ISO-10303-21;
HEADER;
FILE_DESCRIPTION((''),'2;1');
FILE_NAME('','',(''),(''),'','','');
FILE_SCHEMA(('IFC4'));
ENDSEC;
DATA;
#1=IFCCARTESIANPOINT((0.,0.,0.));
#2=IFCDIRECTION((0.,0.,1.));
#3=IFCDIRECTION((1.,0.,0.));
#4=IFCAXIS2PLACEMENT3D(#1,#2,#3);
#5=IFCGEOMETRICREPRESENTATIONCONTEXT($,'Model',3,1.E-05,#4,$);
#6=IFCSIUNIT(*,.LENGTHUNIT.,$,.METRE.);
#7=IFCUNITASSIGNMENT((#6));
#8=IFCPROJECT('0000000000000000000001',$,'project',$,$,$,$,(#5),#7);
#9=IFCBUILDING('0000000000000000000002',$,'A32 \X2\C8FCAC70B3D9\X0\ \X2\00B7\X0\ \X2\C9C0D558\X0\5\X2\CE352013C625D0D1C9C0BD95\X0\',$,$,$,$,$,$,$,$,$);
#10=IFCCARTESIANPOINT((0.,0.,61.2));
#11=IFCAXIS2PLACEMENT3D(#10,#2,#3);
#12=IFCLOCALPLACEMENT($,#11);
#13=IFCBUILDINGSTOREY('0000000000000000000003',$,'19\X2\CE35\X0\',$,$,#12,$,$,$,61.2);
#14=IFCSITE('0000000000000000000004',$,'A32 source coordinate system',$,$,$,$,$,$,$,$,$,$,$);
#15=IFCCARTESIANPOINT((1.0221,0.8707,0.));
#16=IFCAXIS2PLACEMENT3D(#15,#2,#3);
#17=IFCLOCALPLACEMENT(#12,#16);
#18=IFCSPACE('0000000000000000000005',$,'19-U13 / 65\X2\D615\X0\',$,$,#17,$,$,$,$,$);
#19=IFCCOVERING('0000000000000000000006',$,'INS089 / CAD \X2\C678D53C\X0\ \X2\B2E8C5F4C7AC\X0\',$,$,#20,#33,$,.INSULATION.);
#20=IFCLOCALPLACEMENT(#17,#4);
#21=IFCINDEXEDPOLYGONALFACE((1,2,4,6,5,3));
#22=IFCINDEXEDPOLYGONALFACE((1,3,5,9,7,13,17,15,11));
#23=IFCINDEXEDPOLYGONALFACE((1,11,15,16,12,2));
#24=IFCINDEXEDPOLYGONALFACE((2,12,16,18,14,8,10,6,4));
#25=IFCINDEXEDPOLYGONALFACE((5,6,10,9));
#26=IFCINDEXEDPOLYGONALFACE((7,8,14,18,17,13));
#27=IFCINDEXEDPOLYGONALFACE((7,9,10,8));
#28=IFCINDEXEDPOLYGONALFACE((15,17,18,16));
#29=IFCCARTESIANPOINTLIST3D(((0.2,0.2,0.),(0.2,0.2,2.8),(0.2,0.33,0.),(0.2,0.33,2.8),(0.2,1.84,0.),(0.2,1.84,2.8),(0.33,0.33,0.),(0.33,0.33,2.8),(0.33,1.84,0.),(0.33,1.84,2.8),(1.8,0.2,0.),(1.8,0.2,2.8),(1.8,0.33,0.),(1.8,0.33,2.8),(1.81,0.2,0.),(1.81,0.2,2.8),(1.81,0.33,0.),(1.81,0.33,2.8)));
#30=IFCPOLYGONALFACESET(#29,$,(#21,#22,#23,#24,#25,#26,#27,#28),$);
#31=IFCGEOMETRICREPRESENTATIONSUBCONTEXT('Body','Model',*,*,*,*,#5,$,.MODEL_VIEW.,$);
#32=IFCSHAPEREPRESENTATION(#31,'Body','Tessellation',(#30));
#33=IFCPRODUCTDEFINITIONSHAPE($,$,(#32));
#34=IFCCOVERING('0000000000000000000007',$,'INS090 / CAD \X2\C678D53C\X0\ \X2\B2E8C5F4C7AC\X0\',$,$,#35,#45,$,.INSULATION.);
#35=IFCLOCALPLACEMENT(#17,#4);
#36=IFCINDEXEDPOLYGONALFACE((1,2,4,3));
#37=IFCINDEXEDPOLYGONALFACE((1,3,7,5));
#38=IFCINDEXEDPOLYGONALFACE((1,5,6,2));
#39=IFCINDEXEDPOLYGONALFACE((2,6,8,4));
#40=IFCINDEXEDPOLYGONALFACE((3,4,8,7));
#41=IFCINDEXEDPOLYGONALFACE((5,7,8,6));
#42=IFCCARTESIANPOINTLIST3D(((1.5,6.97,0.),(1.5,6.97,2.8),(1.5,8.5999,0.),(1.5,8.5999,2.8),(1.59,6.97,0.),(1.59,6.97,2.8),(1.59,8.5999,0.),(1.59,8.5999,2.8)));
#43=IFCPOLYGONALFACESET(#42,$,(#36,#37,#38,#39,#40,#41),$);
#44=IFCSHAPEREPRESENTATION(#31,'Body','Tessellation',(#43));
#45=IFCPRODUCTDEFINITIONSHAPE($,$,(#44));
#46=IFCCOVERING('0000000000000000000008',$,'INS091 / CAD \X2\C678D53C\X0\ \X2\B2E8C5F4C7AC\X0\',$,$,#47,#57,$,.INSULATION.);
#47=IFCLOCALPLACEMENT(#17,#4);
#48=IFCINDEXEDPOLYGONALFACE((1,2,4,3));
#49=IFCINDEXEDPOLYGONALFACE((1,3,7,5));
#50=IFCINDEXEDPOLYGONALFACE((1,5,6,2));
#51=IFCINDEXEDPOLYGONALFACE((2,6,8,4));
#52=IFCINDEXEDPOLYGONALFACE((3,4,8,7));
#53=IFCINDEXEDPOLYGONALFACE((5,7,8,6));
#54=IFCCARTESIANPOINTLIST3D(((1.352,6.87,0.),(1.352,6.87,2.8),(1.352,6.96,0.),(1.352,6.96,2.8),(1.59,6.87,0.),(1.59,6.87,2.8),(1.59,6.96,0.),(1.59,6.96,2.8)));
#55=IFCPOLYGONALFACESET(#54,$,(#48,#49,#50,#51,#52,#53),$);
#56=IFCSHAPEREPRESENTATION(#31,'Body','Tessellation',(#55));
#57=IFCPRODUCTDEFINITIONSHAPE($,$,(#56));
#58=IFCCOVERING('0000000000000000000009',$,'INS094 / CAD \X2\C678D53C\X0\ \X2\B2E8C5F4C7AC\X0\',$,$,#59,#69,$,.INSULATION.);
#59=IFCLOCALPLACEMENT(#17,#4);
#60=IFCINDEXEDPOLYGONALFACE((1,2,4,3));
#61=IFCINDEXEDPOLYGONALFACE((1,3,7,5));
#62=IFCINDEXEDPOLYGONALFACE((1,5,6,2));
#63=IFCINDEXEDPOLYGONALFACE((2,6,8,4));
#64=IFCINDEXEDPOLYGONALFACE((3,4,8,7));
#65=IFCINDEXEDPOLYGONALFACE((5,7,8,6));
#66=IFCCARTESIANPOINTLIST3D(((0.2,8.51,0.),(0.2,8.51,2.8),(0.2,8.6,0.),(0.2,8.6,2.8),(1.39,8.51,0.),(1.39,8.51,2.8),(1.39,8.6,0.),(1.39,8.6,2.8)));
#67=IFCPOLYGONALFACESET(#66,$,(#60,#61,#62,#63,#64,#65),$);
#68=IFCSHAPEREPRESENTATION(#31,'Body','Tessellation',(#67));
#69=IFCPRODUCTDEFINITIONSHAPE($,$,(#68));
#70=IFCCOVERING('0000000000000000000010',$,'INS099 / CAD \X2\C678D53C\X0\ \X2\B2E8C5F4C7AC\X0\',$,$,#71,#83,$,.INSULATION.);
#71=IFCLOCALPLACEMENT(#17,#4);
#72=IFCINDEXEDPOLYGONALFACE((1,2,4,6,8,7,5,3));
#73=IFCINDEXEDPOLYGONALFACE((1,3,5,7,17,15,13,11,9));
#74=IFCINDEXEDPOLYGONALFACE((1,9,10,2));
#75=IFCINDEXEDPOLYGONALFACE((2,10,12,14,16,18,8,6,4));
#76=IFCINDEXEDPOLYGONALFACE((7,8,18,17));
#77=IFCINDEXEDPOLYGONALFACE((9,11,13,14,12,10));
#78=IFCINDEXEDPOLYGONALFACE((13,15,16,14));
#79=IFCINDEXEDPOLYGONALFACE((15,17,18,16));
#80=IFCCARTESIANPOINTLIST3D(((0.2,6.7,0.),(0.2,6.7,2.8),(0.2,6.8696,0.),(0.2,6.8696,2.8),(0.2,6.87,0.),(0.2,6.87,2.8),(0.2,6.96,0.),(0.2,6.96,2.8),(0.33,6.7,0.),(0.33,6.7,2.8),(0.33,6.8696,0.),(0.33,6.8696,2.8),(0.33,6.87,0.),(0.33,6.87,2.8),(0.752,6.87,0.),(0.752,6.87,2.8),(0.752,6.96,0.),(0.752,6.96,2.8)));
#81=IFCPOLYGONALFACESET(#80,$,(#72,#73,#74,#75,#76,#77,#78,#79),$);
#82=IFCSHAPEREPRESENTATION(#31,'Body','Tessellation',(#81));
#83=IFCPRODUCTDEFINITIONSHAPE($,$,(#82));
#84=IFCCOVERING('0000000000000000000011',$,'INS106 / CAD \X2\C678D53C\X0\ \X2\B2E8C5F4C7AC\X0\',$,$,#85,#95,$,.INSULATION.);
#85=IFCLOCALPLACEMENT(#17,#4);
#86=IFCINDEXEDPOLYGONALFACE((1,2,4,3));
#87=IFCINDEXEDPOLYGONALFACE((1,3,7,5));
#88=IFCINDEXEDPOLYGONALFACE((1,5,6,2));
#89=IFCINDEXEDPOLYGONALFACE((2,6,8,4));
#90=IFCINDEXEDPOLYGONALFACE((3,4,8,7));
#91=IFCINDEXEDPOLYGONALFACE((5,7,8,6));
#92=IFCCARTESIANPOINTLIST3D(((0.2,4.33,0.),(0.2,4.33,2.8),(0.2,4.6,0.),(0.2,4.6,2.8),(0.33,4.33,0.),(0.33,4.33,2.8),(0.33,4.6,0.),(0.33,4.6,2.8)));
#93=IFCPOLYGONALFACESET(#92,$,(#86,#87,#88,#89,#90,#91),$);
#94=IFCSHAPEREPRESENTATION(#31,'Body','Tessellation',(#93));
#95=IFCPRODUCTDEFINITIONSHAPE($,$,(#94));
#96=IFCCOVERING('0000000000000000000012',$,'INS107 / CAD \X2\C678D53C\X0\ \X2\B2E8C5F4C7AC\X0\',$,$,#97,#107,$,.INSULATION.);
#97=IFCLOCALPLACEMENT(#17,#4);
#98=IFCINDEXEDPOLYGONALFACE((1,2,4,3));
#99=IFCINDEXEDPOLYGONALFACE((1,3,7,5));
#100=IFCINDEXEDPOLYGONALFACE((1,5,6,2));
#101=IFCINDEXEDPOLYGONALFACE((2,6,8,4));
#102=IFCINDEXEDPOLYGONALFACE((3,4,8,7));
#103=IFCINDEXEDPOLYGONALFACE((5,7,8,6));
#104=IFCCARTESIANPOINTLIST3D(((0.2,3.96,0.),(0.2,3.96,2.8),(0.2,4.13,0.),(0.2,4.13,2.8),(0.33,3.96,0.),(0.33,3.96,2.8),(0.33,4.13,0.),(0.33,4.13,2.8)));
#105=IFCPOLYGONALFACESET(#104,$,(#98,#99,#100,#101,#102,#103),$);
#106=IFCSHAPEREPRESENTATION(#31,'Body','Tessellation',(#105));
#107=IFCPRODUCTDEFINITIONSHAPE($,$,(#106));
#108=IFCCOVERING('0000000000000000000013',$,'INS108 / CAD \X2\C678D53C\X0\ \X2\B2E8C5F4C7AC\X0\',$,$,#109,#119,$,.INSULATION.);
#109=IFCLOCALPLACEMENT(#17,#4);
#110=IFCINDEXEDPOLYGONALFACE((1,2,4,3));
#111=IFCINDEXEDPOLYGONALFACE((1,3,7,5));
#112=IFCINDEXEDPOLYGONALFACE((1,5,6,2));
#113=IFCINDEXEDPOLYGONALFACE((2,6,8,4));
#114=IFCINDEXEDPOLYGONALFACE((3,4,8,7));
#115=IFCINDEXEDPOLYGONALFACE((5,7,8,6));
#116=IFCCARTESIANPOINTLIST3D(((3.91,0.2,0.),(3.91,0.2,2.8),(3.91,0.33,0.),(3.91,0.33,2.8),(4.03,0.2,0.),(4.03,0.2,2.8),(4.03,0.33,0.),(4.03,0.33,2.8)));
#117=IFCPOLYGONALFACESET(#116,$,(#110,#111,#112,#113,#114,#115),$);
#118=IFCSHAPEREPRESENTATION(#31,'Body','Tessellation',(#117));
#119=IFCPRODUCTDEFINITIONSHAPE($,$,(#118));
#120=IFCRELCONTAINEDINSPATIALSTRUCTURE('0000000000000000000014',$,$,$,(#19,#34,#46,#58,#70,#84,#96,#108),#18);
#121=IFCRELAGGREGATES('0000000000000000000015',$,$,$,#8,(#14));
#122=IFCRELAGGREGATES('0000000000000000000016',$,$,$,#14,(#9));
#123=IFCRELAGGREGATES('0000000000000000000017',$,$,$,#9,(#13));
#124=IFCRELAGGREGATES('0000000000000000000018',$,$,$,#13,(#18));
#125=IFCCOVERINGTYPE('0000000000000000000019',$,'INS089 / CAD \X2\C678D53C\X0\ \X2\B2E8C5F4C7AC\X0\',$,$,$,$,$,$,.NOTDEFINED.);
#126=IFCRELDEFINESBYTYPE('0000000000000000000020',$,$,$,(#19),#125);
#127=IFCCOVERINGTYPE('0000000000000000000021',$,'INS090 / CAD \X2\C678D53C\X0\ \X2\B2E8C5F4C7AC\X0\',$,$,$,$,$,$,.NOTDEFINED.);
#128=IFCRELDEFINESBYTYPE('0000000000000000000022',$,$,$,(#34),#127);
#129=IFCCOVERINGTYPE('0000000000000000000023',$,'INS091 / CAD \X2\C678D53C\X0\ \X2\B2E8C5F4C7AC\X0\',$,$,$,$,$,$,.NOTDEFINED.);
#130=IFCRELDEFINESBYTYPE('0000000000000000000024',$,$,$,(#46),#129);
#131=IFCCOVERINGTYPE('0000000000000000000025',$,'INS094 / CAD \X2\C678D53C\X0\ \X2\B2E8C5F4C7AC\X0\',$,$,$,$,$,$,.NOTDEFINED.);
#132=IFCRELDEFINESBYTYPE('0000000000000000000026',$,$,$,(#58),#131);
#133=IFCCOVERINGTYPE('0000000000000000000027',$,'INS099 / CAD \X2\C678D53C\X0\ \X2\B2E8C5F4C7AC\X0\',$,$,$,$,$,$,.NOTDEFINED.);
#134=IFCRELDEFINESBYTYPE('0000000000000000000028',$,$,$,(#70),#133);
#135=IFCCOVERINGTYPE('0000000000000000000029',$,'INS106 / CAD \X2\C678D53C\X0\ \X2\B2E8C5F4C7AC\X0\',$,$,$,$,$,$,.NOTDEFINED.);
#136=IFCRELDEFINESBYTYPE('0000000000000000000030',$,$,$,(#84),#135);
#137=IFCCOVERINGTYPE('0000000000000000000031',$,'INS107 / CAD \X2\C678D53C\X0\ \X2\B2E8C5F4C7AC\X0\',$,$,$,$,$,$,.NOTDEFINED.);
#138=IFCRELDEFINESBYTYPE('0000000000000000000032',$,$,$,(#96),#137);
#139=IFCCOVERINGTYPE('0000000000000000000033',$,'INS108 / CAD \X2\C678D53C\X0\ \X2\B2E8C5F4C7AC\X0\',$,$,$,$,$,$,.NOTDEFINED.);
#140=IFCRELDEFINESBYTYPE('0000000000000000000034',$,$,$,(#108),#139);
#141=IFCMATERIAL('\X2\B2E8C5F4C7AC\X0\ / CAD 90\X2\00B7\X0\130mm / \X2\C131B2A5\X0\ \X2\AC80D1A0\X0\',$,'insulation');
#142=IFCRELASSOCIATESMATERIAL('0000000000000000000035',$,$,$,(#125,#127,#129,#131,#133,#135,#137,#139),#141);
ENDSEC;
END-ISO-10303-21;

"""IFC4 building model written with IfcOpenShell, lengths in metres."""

from ifc_helpers import new_model, si_unit, frame, origin, origin_with_axes, place, context, subcontext, project, spatial, polyline, outline, extrude, source, transform, mapped, material, type_object, type_shapes, element, save


model = new_model("IFC4")

# Units and contexts
model_context = context("Model", 3, precision=1e-05, world=origin_with_axes())
body_context = subcontext(model_context, "Body", "Model", "MODEL_VIEW")
ifc_project = project(units=[si_unit("LENGTHUNIT", "METRE")], contexts=[model_context])

# Site, building, storey
site = spatial("IfcSite", under=ifc_project, Name="A32 source coordinate system")
building = spatial("IfcBuilding", under=site, Name="A32 주거동 · 지하5층–옥탑지붕")
storey_placement = place(None, frame((0.0, 0.0, 61.2), z_axis=(0.0, 0.0, 1.0), x_axis=(1.0, 0.0, 0.0)))
storey = spatial("IfcBuildingStorey", under=building, at=storey_placement, Name="19층", Elevation=61.2)

# Shared definitions
space_placement = place(storey_placement, frame((1.0221, 0.8707, 0.0), z_axis=(0.0, 0.0, 1.0), x_axis=(1.0, 0.0, 0.0)))
space = spatial("IfcSpace", under=storey, at=space_placement, Name="19-U13 / 65형")

# Coverings
ifc_material = material(Name="단열재 / CAD 90·130mm / 성능 검토", Category="insulation")
covering_type_1 = type_object("IfcCoveringType", Name="INS089 / CAD 외피 단열재", PredefinedType="NOTDEFINED", material=ifc_material)
shared_shape_1 = source(origin(), body_context, "Body", "SweptSolid", [
    extrude(outline(polyline([(0.2, 0.33), (0.2, 1.84), (0.33, 1.84), (0.33, 0.33), (1.8, 0.33), (1.81, 0.33), (1.81, 0.2), (1.8, 0.2), (0.2, 0.2), (0.2, 0.33)])), origin(), (0.0, 0.0, 1.0), 2.8),
])
type_shapes(covering_type_1, [shared_shape_1])
covering_1_placement = place(space_placement, origin_with_axes())
element("IfcCovering", 1, at=covering_1_placement, inside=space, type_object=covering_type_1, Name="INS089 / CAD 외피 단열재", PredefinedType="INSULATION", context=body_context, shape_type="MappedRepresentation", body=[
    mapped(shared_shape_1, transform((0.0, 0.0, 0.0), scale=1.0)),
])
covering_type_2 = type_object("IfcCoveringType", Name="INS090 / CAD 외피 단열재", PredefinedType="NOTDEFINED", material=ifc_material)
shared_shape_2 = source(origin(), body_context, "Body", "SweptSolid", [
    extrude(outline(polyline([(1.59, 6.97), (1.5, 6.97), (1.5, 8.5999), (1.59, 8.5999), (1.59, 6.97)])), origin(), (0.0, 0.0, 1.0), 2.8),
])
type_shapes(covering_type_2, [shared_shape_2])
covering_2_placement = place(space_placement, origin_with_axes())
element("IfcCovering", 2, at=covering_2_placement, inside=space, type_object=covering_type_2, Name="INS090 / CAD 외피 단열재", PredefinedType="INSULATION", context=body_context, shape_type="MappedRepresentation", body=[
    mapped(shared_shape_2, transform((0.0, 0.0, 0.0), scale=1.0)),
])
covering_type_3 = type_object("IfcCoveringType", Name="INS091 / CAD 외피 단열재", PredefinedType="NOTDEFINED", material=ifc_material)
shared_shape_3 = source(origin(), body_context, "Body", "SweptSolid", [
    extrude(outline(polyline([(1.59, 6.96), (1.59, 6.87), (1.352, 6.87), (1.352, 6.96), (1.59, 6.96)])), origin(), (0.0, 0.0, 1.0), 2.8),
])
type_shapes(covering_type_3, [shared_shape_3])
covering_3_placement = place(space_placement, origin_with_axes())
element("IfcCovering", 3, at=covering_3_placement, inside=space, type_object=covering_type_3, Name="INS091 / CAD 외피 단열재", PredefinedType="INSULATION", context=body_context, shape_type="MappedRepresentation", body=[
    mapped(shared_shape_3, transform((0.0, 0.0, 0.0), scale=1.0)),
])
covering_type_4 = type_object("IfcCoveringType", Name="INS094 / CAD 외피 단열재", PredefinedType="NOTDEFINED", material=ifc_material)
shared_shape_4 = source(origin(), body_context, "Body", "SweptSolid", [
    extrude(outline(polyline([(1.39, 8.51), (0.2, 8.51), (0.2, 8.6), (1.39, 8.6), (1.39, 8.51)])), origin(), (0.0, 0.0, 1.0), 2.8),
])
type_shapes(covering_type_4, [shared_shape_4])
covering_4_placement = place(space_placement, origin_with_axes())
element("IfcCovering", 4, at=covering_4_placement, inside=space, type_object=covering_type_4, Name="INS094 / CAD 외피 단열재", PredefinedType="INSULATION", context=body_context, shape_type="MappedRepresentation", body=[
    mapped(shared_shape_4, transform((0.0, 0.0, 0.0), scale=1.0)),
])
covering_type_5 = type_object("IfcCoveringType", Name="INS099 / CAD 외피 단열재", PredefinedType="NOTDEFINED", material=ifc_material)
shared_shape_5 = source(origin(), body_context, "Body", "SweptSolid", [
    extrude(outline(polyline([(0.2, 6.8696), (0.2, 6.87), (0.2, 6.96), (0.752, 6.96), (0.752, 6.87), (0.33, 6.87), (0.33, 6.8696), (0.33, 6.7), (0.2, 6.7), (0.2, 6.8696)])), origin(), (0.0, 0.0, 1.0), 2.8),
])
type_shapes(covering_type_5, [shared_shape_5])
covering_5_placement = place(space_placement, origin_with_axes())
element("IfcCovering", 5, at=covering_5_placement, inside=space, type_object=covering_type_5, Name="INS099 / CAD 외피 단열재", PredefinedType="INSULATION", context=body_context, shape_type="MappedRepresentation", body=[
    mapped(shared_shape_5, transform((0.0, 0.0, 0.0), scale=1.0)),
])
covering_type_6 = type_object("IfcCoveringType", Name="INS106 / CAD 외피 단열재", PredefinedType="NOTDEFINED", material=ifc_material)
shared_shape_6 = source(origin(), body_context, "Body", "SweptSolid", [
    extrude(outline(polyline([(0.33, 4.6), (0.33, 4.33), (0.2, 4.33), (0.2, 4.6), (0.33, 4.6)])), origin(), (0.0, 0.0, 1.0), 2.8),
])
type_shapes(covering_type_6, [shared_shape_6])
covering_6_placement = place(space_placement, origin_with_axes())
element("IfcCovering", 6, at=covering_6_placement, inside=space, type_object=covering_type_6, Name="INS106 / CAD 외피 단열재", PredefinedType="INSULATION", context=body_context, shape_type="MappedRepresentation", body=[
    mapped(shared_shape_6, transform((0.0, 0.0, 0.0), scale=1.0)),
])
covering_type_7 = type_object("IfcCoveringType", Name="INS107 / CAD 외피 단열재", PredefinedType="NOTDEFINED", material=ifc_material)
shared_shape_7 = source(origin(), body_context, "Body", "SweptSolid", [
    extrude(outline(polyline([(0.33, 3.96), (0.2, 3.96), (0.2, 4.13), (0.33, 4.13), (0.33, 3.96)])), origin(), (0.0, 0.0, 1.0), 2.8),
])
type_shapes(covering_type_7, [shared_shape_7])
covering_7_placement = place(space_placement, origin_with_axes())
element("IfcCovering", 7, at=covering_7_placement, inside=space, type_object=covering_type_7, Name="INS107 / CAD 외피 단열재", PredefinedType="INSULATION", context=body_context, shape_type="MappedRepresentation", body=[
    mapped(shared_shape_7, transform((0.0, 0.0, 0.0), scale=1.0)),
])
covering_type_8 = type_object("IfcCoveringType", Name="INS108 / CAD 외피 단열재", PredefinedType="NOTDEFINED", material=ifc_material)
shared_shape_8 = source(origin(), body_context, "Body", "SweptSolid", [
    extrude(outline(polyline([(4.03, 0.2), (3.91, 0.2), (3.91, 0.33), (4.03, 0.33), (4.03, 0.2)])), origin(), (0.0, 0.0, 1.0), 2.8),
])
type_shapes(covering_type_8, [shared_shape_8])
covering_8_placement = place(space_placement, origin_with_axes())
element("IfcCovering", 8, at=covering_8_placement, inside=space, type_object=covering_type_8, Name="INS108 / CAD 외피 단열재", PredefinedType="INSULATION", context=body_context, shape_type="MappedRepresentation", body=[
    mapped(shared_shape_8, transform((0.0, 0.0, 0.0), scale=1.0)),
])

save(model, "model.ifc")
